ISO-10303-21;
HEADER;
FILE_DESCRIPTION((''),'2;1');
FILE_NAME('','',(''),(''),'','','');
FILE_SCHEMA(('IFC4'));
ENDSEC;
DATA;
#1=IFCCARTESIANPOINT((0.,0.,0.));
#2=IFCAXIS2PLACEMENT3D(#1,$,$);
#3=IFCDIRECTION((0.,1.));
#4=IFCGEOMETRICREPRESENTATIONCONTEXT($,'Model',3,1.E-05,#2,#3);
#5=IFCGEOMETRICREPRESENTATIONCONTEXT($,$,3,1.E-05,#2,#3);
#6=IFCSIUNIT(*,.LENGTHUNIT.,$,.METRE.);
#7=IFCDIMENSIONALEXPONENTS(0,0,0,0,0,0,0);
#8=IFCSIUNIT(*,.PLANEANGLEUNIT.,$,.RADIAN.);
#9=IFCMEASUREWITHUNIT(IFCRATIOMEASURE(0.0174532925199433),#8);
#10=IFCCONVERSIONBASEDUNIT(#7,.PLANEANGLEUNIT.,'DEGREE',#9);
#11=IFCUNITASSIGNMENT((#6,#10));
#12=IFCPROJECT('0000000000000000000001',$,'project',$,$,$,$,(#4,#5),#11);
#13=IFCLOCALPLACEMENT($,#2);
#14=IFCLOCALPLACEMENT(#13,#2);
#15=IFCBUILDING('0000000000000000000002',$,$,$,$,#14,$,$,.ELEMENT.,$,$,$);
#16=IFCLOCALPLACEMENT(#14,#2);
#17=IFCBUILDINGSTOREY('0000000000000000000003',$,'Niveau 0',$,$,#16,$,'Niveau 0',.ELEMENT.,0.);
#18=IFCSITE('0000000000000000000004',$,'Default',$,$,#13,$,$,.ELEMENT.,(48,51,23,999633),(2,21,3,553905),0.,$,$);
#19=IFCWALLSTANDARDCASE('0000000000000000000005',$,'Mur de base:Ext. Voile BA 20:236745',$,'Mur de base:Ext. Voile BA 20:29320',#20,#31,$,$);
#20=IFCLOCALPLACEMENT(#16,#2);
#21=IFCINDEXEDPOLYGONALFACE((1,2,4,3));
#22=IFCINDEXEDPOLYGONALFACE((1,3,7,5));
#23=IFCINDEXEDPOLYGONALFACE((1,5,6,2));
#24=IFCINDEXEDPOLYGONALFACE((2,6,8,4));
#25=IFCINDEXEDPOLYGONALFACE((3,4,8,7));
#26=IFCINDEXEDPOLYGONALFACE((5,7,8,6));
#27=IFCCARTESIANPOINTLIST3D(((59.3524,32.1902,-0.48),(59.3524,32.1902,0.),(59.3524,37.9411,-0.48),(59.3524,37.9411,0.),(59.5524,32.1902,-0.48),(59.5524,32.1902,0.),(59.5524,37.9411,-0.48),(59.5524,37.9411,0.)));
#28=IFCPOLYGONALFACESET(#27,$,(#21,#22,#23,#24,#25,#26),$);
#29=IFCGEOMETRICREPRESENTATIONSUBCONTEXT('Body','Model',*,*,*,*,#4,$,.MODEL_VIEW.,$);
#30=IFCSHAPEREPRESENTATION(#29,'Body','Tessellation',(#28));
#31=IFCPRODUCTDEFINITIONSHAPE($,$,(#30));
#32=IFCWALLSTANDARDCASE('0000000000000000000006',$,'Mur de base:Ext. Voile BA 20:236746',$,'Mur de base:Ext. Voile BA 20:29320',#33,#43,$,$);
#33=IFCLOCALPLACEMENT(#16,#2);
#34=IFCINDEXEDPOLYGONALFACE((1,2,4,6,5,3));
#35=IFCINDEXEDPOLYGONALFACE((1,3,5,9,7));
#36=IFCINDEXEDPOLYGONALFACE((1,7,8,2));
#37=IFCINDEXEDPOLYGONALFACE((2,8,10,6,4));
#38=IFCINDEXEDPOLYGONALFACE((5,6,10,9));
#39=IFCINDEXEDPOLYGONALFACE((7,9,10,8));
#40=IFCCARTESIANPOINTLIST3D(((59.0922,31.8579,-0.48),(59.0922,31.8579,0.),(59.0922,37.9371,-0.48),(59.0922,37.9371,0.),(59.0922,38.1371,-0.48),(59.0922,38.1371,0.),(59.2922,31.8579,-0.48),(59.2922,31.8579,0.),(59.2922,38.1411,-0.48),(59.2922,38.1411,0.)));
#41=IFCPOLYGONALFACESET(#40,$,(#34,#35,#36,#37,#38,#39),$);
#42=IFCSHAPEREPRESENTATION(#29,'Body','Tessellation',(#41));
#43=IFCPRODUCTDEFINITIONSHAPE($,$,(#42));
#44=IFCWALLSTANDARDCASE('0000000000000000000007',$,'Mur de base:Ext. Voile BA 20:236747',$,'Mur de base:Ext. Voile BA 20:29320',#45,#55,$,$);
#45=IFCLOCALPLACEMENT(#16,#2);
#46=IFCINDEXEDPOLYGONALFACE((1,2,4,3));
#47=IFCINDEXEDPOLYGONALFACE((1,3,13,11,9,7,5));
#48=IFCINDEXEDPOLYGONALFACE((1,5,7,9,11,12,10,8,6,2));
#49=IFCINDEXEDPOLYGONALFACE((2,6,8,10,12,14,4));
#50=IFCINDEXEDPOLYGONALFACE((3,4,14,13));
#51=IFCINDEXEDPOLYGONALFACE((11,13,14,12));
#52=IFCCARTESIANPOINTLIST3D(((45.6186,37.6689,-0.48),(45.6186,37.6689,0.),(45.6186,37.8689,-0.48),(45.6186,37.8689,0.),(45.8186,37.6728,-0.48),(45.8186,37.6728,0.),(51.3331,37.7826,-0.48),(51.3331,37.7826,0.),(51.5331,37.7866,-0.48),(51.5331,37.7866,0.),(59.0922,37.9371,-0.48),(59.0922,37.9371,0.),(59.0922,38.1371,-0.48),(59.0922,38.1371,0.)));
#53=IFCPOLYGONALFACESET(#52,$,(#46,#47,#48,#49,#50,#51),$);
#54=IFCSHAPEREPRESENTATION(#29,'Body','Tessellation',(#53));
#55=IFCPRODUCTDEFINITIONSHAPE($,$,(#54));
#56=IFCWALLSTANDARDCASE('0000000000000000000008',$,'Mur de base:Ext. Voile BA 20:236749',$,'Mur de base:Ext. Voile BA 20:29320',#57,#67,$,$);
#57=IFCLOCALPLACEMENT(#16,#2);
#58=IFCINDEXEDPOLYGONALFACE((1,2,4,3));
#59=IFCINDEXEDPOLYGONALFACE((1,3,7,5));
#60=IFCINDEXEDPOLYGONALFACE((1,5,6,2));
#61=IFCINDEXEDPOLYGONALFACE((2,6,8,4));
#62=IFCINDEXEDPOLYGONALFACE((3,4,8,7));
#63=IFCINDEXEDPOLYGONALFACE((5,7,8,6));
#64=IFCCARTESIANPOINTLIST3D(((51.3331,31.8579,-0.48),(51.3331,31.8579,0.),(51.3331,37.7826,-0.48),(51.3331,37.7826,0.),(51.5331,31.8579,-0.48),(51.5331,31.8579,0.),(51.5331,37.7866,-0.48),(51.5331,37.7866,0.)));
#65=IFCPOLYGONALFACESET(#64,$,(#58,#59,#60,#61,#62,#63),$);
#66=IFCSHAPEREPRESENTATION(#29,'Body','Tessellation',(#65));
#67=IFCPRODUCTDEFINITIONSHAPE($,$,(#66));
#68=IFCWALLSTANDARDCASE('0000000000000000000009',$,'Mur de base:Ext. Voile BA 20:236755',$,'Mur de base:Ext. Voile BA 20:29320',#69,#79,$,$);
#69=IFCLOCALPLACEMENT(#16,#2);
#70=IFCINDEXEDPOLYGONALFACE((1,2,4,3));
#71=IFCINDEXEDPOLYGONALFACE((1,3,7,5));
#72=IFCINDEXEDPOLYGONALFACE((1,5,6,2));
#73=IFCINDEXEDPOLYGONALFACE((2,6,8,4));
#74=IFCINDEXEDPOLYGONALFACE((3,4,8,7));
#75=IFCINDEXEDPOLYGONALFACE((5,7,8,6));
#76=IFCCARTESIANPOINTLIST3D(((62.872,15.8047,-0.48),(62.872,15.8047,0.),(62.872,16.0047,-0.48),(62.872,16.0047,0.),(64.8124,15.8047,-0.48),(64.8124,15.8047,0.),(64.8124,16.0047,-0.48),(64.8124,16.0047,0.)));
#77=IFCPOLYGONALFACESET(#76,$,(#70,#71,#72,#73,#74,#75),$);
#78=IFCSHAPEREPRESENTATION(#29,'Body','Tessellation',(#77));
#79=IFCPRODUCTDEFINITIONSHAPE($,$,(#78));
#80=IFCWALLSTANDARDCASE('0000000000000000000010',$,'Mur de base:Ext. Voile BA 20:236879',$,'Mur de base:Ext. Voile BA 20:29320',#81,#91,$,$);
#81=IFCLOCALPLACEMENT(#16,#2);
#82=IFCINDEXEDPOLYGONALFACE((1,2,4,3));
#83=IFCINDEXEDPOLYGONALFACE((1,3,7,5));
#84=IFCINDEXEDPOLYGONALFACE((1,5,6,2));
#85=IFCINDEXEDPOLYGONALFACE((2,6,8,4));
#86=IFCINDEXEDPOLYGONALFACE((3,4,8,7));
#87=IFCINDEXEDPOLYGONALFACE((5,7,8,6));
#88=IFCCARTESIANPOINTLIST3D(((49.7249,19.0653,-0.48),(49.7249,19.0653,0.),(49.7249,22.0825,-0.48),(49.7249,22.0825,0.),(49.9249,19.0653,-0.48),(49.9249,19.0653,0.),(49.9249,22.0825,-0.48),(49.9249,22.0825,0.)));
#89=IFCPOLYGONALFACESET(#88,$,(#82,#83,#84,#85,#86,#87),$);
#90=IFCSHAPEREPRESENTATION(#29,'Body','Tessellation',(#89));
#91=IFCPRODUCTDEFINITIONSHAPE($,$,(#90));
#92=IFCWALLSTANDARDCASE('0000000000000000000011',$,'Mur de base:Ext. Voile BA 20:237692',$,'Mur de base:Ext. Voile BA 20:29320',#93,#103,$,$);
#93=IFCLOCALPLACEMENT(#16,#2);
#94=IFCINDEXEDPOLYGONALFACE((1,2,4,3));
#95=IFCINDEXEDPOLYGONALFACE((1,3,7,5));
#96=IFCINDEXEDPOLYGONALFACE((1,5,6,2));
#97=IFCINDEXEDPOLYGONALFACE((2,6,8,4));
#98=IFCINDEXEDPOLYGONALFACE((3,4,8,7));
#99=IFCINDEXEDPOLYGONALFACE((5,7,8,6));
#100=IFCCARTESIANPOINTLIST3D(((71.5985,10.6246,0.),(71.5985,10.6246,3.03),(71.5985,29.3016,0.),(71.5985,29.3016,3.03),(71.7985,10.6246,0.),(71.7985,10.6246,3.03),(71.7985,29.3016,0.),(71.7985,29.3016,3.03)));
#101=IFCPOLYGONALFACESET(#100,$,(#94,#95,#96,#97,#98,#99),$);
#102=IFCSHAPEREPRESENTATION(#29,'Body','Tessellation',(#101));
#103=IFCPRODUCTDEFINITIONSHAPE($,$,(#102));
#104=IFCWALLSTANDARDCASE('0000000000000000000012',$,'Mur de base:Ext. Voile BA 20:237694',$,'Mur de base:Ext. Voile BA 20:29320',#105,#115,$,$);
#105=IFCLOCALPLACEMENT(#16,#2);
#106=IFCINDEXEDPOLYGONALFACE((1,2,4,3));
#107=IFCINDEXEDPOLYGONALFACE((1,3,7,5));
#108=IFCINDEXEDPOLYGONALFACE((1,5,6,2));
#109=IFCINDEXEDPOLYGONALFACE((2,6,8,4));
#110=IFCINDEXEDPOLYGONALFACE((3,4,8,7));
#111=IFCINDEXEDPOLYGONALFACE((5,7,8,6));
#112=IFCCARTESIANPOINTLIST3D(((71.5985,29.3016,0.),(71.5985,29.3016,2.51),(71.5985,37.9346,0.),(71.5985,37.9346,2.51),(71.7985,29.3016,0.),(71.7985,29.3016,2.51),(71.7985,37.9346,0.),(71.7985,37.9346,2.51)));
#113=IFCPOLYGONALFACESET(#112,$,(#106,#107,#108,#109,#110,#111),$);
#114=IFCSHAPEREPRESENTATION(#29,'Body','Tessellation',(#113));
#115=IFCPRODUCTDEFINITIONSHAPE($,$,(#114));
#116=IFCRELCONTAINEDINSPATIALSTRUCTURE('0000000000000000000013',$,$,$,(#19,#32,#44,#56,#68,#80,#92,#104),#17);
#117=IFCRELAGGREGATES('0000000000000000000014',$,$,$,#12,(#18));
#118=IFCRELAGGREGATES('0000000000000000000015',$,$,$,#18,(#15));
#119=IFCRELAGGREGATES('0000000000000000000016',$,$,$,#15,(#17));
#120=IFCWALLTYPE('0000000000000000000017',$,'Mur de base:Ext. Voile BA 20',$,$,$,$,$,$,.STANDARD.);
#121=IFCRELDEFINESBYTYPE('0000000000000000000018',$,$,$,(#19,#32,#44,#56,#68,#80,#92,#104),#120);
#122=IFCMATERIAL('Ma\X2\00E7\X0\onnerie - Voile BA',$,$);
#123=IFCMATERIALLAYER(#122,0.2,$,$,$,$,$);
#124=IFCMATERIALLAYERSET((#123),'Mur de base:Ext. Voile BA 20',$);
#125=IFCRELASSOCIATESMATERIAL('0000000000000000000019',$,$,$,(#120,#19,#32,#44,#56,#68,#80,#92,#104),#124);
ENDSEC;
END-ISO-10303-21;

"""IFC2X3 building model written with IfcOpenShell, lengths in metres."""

from ifc_helpers import new_model, entity, si_unit, converted_unit, direction, frame, frame_2d, origin, place, context, subcontext, project, spatial, polyline, rectangle, outline, extrude, material, layer, layer_set, layer_usage, type_object, element, save


model = new_model("IFC2X3")

# Units and contexts
model_context = context("Model", 3, precision=1e-05, world=origin(), true_north=direction((0.0, 1.0)))
context_of_model = context(None, 3, precision=1e-05, world=origin(), true_north=direction((0.0, 1.0)))
body_context = subcontext(model_context, "Body", "Model", "MODEL_VIEW")
ifc_project = project(units=[si_unit("LENGTHUNIT", "METRE"), converted_unit("PLANEANGLEUNIT", "DEGREE", entity("IfcRatioMeasure", 0.0174532925199433), si_unit("PLANEANGLEUNIT", "RADIAN"), dimensions=[0, 0, 0, 0, 0, 0, 0])], contexts=[model_context, context_of_model])

# Site, building, storey
site_placement = place(None, origin())
site = spatial("IfcSite", under=ifc_project, at=site_placement, Name="Default", CompositionType="ELEMENT", RefLatitude=(48, 51, 23, 999633), RefLongitude=(2, 21, 3, 553905), RefElevation=0.0)
building_placement = place(site_placement, origin())
building = spatial("IfcBuilding", under=site, at=building_placement, CompositionType="ELEMENT")
storey_placement = place(building_placement, origin())
storey = spatial("IfcBuildingStorey", under=building, at=storey_placement, Name="Niveau 0", LongName="Niveau 0", CompositionType="ELEMENT", Elevation=0.0)

# Walls
ifc_material_1 = material(Name="Maçonnerie - Voile BA")
ifc_layer = layer(ifc_material_1, 0.2)
ifc_layer_set = layer_set([ifc_layer], Name="Mur de base:Ext. Voile BA 20")
wall_type = type_object("IfcWallType", Name="Mur de base:Ext. Voile BA 20", PredefinedType="STANDARD", material=ifc_layer_set)
ifc_layer_usage_1 = layer_usage(ifc_layer_set, "AXIS2", "NEGATIVE", 0.1)
wall_1_placement = place(storey_placement, frame((59.4524, 37.9411, -0.48), z_axis=(0.0, 0.0, 1.0), x_axis=(0.0, -1.0, 0.0)))
element("IfcWallStandardCase", 1, at=wall_1_placement, inside=storey, type_object=wall_type, material=ifc_layer_usage_1, Name="Mur de base:Ext. Voile BA 20:236745", ObjectType="Mur de base:Ext. Voile BA 20:29320", context=body_context, shape_type="SweptSolid", body=[
    extrude(rectangle(XDim=5.7509, YDim=0.2, at=frame_2d((2.8755, 0.0), x_axis=(-1.0, 0.0))), origin(), (0.0, 0.0, 1.0), 0.48),
])
ifc_layer_usage_2 = layer_usage(ifc_layer_set, "AXIS2", "NEGATIVE", 0.1)
wall_2_placement = place(storey_placement, frame((59.1922, 31.8579, -0.48), z_axis=(0.0, 0.0, 1.0), x_axis=(0.0, 1.0, 0.0)))
element("IfcWallStandardCase", 2, at=wall_2_placement, inside=storey, type_object=wall_type, material=ifc_layer_usage_2, Name="Mur de base:Ext. Voile BA 20:236746", ObjectType="Mur de base:Ext. Voile BA 20:29320", context=body_context, shape_type="SweptSolid", body=[
    extrude(outline(polyline([(6.2832, -0.1), (6.2792, 0.1), (6.0792, 0.1), (0.0, 0.1), (0.0, -0.1), (6.2832, -0.1)])), origin(), (0.0, 0.0, 1.0), 0.48),
])
ifc_layer_usage_3 = layer_usage(ifc_layer_set, "AXIS2", "NEGATIVE", 0.1)
wall_3_placement = place(storey_placement, frame((59.0942, 38.0371, -0.48), z_axis=(0.0, 0.0, 1.0), x_axis=(-0.999802, -0.019903, 0.0)))
element("IfcWallStandardCase", 3, at=wall_3_placement, inside=storey, type_object=wall_type, material=ifc_layer_usage_3, Name="Mur de base:Ext. Voile BA 20:236747", ObjectType="Mur de base:Ext. Voile BA 20:29320", context=body_context, shape_type="SweptSolid", body=[
    extrude(outline(polyline([(13.4763, -0.1), (13.4802, 0.1), (13.2802, 0.1), (7.7647, 0.1), (7.5646, 0.1), (0.004, 0.1), (0.0, -0.1), (13.4763, -0.1)])), origin(), (0.0, 0.0, 1.0), 0.48),
])
ifc_layer_usage_4 = layer_usage(ifc_layer_set, "AXIS2", "NEGATIVE", 0.1)
wall_4_placement = place(storey_placement, frame((51.4331, 37.7866, -0.48), z_axis=(0.0, 0.0, 1.0), x_axis=(0.0, -1.0, 0.0)))
element("IfcWallStandardCase", 4, at=wall_4_placement, inside=storey, type_object=wall_type, material=ifc_layer_usage_4, Name="Mur de base:Ext. Voile BA 20:236749", ObjectType="Mur de base:Ext. Voile BA 20:29320", context=body_context, shape_type="SweptSolid", body=[
    extrude(outline(polyline([(5.9287, -0.1), (5.9287, 0.1), (0.0, 0.1), (0.004, -0.1), (5.9287, -0.1)])), origin(), (0.0, 0.0, 1.0), 0.48),
])
ifc_layer_usage_5 = layer_usage(ifc_layer_set, "AXIS2", "NEGATIVE", 0.1)
wall_5_placement = place(storey_placement, frame((62.872, 15.9047, -0.48)))
element("IfcWallStandardCase", 5, at=wall_5_placement, inside=storey, type_object=wall_type, material=ifc_layer_usage_5, Name="Mur de base:Ext. Voile BA 20:236755", ObjectType="Mur de base:Ext. Voile BA 20:29320", context=body_context, shape_type="SweptSolid", body=[
    extrude(rectangle(XDim=1.9404, YDim=0.2, at=frame_2d((0.9702, 0.0), x_axis=(-1.0, 0.0))), origin(), (0.0, 0.0, 1.0), 0.48),
])
ifc_layer_usage_6 = layer_usage(ifc_layer_set, "AXIS2", "NEGATIVE", 0.1)
wall_6_placement = place(storey_placement, frame((49.8249, 22.0825, -0.48), z_axis=(0.0, 0.0, 1.0), x_axis=(0.0, -1.0, 0.0)))
element("IfcWallStandardCase", 6, at=wall_6_placement, inside=storey, type_object=wall_type, material=ifc_layer_usage_6, Name="Mur de base:Ext. Voile BA 20:236879", ObjectType="Mur de base:Ext. Voile BA 20:29320", context=body_context, shape_type="SweptSolid", body=[
    extrude(rectangle(XDim=3.0172, YDim=0.2, at=frame_2d((1.5086, 0.0), x_axis=(-1.0, 0.0))), origin(), (0.0, 0.0, 1.0), 0.48),
])
ifc_layer_usage_7 = layer_usage(ifc_layer_set, "AXIS2", "NEGATIVE", 0.1)
wall_7_placement = place(storey_placement, frame((71.6985, 29.3016, 0.0), z_axis=(0.0, 0.0, 1.0), x_axis=(0.0, -1.0, 0.0)))
element("IfcWallStandardCase", 7, at=wall_7_placement, inside=storey, type_object=wall_type, material=ifc_layer_usage_7, Name="Mur de base:Ext. Voile BA 20:237692", ObjectType="Mur de base:Ext. Voile BA 20:29320", context=body_context, shape_type="SweptSolid", body=[
    extrude(rectangle(XDim=18.677, YDim=0.2, at=frame_2d((9.3385, 0.0), x_axis=(-1.0, 0.0))), origin(), (0.0, 0.0, 1.0), 3.03),
])
ifc_layer_usage_8 = layer_usage(ifc_layer_set, "AXIS2", "POSITIVE", -0.1)
wall_8_placement = place(storey_placement, frame((71.6985, 29.3016, 0.0), z_axis=(0.0, 0.0, 1.0), x_axis=(0.0, 1.0, 0.0)))
element("IfcWallStandardCase", 8, at=wall_8_placement, inside=storey, type_object=wall_type, material=ifc_layer_usage_8, Name="Mur de base:Ext. Voile BA 20:237694", ObjectType="Mur de base:Ext. Voile BA 20:29320", context=body_context, shape_type="SweptSolid", body=[
    extrude(rectangle(XDim=8.633, YDim=0.2, at=frame_2d((4.3165, 0.0), x_axis=(-1.0, 0.0))), origin(), (0.0, 0.0, 1.0), 2.51),
])

save(model, "model.ifc")
